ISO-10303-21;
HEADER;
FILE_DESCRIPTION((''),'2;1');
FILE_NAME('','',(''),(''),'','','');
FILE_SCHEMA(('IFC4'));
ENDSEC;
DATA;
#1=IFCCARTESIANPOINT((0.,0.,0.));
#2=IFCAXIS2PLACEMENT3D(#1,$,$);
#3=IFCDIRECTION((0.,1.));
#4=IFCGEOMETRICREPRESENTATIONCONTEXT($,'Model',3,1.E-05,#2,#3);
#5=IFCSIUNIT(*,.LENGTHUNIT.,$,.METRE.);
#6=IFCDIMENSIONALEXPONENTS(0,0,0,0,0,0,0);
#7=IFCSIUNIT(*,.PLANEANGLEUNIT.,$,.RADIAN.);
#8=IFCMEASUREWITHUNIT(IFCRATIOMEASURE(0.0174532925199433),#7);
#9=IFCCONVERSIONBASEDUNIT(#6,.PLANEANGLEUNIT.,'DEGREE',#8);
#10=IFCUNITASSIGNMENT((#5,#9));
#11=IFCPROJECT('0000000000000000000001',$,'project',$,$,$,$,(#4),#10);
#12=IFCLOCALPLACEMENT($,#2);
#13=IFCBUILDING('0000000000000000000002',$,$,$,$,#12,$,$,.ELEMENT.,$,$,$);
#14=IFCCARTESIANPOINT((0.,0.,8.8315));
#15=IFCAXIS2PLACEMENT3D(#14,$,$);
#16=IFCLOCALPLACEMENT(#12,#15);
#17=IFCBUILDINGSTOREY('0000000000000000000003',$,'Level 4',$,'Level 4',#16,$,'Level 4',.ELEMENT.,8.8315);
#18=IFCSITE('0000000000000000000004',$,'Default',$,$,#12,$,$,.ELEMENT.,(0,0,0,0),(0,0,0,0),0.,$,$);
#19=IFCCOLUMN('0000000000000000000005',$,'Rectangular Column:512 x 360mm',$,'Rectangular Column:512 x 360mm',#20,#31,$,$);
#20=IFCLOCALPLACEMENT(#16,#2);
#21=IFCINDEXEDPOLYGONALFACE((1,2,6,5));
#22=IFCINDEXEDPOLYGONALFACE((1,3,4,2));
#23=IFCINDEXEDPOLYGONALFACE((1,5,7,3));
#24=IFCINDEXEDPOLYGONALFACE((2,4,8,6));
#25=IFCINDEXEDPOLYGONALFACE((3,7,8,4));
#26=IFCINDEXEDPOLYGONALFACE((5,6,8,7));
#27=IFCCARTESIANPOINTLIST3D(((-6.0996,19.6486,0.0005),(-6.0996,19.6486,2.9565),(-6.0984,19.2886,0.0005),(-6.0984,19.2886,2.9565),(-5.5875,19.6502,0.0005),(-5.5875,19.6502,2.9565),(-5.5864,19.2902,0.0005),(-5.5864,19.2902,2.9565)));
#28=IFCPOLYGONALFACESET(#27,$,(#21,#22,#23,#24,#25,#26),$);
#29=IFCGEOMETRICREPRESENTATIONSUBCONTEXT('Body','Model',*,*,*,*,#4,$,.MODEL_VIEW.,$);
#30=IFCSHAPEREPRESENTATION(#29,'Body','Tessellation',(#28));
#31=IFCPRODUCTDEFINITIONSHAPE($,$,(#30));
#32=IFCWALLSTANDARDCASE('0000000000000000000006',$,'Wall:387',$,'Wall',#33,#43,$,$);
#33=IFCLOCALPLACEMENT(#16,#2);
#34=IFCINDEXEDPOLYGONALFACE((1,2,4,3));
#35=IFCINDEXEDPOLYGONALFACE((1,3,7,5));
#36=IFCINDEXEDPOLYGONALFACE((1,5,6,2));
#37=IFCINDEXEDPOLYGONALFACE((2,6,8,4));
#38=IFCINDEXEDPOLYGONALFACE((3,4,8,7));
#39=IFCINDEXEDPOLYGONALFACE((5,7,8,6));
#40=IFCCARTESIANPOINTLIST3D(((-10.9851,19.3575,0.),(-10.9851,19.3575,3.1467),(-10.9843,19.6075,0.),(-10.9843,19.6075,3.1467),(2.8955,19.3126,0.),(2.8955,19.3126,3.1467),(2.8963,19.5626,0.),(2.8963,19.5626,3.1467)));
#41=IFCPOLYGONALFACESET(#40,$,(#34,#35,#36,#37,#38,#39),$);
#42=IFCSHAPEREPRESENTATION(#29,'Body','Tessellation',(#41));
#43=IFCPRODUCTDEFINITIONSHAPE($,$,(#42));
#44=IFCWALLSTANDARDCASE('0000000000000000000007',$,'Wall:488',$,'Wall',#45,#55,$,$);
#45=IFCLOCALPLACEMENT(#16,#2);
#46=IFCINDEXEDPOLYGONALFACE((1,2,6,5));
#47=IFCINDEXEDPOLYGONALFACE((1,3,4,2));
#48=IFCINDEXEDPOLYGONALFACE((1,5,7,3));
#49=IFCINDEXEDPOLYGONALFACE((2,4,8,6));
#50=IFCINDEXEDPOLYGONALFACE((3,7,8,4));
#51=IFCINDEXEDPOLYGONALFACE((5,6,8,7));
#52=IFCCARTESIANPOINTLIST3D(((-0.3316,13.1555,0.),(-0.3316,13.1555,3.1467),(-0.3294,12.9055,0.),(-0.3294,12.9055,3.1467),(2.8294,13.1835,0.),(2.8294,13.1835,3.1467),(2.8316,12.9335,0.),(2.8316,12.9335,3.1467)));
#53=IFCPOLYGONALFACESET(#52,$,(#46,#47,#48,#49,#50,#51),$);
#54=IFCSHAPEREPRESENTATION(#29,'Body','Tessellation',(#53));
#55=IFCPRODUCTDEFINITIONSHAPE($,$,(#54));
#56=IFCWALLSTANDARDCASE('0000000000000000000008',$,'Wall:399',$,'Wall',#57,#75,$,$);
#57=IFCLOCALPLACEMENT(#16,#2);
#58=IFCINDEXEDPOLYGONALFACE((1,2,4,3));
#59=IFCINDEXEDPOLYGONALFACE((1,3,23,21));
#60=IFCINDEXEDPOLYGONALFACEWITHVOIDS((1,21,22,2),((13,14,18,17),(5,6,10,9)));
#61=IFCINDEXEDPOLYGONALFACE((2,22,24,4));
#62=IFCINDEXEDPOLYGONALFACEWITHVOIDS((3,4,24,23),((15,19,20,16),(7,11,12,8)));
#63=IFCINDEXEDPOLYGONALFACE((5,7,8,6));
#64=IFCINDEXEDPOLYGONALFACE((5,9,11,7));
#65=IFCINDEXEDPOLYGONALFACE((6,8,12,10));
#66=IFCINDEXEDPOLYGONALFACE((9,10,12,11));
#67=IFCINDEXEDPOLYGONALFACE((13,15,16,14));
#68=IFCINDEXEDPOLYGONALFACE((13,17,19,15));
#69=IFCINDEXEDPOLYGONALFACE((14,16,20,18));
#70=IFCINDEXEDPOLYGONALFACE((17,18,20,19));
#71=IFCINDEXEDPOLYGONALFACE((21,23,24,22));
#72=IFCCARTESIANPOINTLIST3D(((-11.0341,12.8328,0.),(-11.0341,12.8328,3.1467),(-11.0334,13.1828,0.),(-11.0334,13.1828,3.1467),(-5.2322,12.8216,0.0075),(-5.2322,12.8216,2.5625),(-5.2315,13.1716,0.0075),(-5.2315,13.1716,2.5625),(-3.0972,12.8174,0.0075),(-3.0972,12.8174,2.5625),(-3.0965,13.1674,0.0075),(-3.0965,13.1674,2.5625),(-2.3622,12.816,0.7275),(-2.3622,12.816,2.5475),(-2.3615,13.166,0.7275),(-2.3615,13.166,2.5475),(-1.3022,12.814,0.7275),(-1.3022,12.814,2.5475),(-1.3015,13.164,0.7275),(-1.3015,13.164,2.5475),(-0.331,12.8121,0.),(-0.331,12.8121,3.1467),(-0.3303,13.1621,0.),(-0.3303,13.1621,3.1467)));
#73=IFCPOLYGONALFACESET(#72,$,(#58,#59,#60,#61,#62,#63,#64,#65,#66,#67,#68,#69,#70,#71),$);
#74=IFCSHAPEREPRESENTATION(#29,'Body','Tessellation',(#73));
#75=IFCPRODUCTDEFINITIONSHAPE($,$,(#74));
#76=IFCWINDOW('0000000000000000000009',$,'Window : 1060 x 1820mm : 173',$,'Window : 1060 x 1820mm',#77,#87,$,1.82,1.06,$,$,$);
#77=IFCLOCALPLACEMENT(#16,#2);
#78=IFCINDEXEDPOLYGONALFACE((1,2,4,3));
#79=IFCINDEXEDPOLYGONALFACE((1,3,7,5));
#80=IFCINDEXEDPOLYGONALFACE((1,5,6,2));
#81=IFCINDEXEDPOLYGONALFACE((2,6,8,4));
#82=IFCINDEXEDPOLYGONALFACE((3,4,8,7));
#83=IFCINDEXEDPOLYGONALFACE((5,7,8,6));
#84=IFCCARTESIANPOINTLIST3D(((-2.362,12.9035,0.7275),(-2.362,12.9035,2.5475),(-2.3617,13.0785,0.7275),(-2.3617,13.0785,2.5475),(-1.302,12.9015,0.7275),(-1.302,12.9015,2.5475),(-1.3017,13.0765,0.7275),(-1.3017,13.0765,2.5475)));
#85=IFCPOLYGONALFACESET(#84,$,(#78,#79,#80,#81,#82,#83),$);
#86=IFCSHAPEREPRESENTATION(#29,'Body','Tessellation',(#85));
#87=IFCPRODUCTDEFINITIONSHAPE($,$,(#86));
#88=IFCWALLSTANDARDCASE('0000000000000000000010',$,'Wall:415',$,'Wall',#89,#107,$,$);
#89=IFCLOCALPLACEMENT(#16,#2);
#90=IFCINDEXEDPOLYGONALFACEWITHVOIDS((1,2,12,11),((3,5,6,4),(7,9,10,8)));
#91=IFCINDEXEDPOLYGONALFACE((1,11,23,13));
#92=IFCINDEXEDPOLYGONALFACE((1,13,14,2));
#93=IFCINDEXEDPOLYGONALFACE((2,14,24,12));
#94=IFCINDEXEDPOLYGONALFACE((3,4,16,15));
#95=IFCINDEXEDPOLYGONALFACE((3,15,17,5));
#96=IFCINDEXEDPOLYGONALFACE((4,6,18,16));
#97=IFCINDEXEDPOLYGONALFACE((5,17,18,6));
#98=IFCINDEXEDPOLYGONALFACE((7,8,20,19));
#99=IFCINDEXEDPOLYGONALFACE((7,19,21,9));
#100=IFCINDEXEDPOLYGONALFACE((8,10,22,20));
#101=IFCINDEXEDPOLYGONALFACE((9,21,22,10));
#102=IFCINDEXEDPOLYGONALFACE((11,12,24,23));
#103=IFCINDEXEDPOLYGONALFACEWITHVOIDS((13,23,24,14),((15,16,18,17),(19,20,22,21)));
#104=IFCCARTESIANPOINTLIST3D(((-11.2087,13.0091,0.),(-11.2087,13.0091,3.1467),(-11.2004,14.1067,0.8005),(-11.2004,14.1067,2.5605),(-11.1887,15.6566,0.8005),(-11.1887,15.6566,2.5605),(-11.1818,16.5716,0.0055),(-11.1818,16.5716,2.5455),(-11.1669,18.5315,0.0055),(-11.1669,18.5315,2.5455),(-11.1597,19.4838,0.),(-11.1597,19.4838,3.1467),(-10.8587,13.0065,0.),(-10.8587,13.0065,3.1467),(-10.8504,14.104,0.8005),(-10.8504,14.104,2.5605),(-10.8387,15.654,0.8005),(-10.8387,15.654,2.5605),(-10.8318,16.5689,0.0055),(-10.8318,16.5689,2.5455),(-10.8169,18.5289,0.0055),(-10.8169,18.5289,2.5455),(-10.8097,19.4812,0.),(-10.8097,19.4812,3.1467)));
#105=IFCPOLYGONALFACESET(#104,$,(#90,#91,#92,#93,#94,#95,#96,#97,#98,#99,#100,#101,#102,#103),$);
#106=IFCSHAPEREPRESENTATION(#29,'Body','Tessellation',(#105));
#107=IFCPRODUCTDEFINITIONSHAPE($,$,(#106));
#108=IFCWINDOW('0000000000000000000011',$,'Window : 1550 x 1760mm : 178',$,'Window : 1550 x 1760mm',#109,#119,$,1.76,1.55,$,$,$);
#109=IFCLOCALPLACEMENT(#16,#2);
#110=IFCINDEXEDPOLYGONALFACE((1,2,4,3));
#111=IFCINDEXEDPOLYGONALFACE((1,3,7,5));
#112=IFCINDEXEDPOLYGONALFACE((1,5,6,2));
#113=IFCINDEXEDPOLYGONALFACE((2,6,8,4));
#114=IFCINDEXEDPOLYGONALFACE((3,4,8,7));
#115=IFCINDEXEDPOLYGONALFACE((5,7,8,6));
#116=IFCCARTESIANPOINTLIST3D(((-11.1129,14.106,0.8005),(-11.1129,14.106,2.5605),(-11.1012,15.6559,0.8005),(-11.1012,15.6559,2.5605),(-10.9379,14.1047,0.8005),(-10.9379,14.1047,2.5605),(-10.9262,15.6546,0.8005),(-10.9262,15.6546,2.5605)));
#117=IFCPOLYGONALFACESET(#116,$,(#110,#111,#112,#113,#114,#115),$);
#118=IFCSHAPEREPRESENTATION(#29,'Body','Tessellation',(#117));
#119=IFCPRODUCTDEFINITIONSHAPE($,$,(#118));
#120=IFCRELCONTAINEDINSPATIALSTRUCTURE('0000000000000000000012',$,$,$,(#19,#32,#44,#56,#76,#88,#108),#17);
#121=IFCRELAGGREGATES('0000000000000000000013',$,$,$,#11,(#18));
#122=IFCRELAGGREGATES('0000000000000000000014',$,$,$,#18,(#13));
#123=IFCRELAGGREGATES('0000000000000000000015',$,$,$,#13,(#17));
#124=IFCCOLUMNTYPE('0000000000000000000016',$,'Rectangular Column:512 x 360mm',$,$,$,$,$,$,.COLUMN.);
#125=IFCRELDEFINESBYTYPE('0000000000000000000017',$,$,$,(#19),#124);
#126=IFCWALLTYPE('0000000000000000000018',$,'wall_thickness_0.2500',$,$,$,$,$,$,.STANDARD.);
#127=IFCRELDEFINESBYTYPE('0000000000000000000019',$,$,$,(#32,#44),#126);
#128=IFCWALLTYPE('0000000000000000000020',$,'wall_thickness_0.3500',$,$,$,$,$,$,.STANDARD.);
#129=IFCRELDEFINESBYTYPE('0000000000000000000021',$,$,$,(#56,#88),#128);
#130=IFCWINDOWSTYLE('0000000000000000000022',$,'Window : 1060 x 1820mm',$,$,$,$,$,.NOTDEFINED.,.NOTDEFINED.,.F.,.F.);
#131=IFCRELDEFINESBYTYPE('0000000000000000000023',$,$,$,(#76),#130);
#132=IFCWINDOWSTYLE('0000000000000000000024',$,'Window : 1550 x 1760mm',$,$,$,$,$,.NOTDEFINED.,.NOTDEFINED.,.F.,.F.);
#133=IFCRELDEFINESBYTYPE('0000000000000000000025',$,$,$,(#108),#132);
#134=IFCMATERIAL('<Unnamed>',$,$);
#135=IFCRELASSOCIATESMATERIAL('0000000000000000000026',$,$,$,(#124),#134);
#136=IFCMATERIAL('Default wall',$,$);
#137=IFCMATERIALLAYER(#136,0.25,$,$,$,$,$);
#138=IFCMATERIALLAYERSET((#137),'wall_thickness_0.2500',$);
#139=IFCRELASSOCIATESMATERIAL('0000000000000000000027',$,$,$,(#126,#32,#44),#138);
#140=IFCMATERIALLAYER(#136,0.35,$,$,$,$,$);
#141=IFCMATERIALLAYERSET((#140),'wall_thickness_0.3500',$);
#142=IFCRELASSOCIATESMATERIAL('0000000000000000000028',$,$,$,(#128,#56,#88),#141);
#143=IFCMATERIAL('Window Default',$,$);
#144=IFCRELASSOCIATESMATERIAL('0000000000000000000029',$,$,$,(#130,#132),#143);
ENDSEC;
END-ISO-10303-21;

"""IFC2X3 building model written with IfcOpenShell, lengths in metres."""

from ifc_helpers import new_model, entity, si_unit, converted_unit, direction, frame, frame_2d, origin, origin_2d_with_axis, place, context, subcontext, project, spatial, polyline, rectangle, outline, extrude, source, transform, mapped, material, layer, layer_set, layer_usage, type_object, type_shapes, element, fill, save


model = new_model("IFC2X3")

# Units and contexts
model_context = context("Model", 3, precision=1e-05, world=origin(), true_north=direction((0.0, 1.0)))
body_context = subcontext(model_context, "Body", "Model", "MODEL_VIEW")
ifc_project = project(units=[si_unit("LENGTHUNIT", "METRE"), converted_unit("PLANEANGLEUNIT", "DEGREE", entity("IfcRatioMeasure", 0.0174532925199433), si_unit("PLANEANGLEUNIT", "RADIAN"), dimensions=[0, 0, 0, 0, 0, 0, 0])], contexts=[model_context])

# Site, building, storey
placement = place(None, origin())
site = spatial("IfcSite", under=ifc_project, at=placement, Name="Default", CompositionType="ELEMENT", RefLatitude=(0, 0, 0, 0), RefLongitude=(0, 0, 0, 0), RefElevation=0.0)
building = spatial("IfcBuilding", under=site, at=placement, CompositionType="ELEMENT")
storey_placement = place(placement, frame((0.0, 0.0, 8.8315)))
storey = spatial("IfcBuildingStorey", under=building, at=storey_placement, Name="Level 4", ObjectType="Level 4", LongName="Level 4", CompositionType="ELEMENT", Elevation=8.8315)

# Column
ifc_material_1 = material(Name="<Unnamed>")
column_type = type_object("IfcColumnType", Name="Rectangular Column:512 x 360mm", PredefinedType="COLUMN", material=ifc_material_1)
shared_shape_1 = source(origin(), body_context, "Body", "SweptSolid", [
    extrude(rectangle(XDim=0.5121, YDim=0.36, at=origin_2d_with_axis()), frame((0.0, 0.0, 0.0), z_axis=(0.0, 0.0, 1.0), x_axis=(0.0, -1.0, 0.0)), (0.0, 0.0, 1.0), 2.956),
])
type_shapes(column_type, [shared_shape_1])
column_placement = place(placement, frame((-5.843, 19.4694, 8.832), z_axis=(0.0, 0.0, 1.0), x_axis=(0.003156, -0.999995, 0.0)))
element("IfcColumn", 1, at=column_placement, inside=storey, type_object=column_type, Name="Rectangular Column:512 x 360mm", ObjectType="Rectangular Column:512 x 360mm", context=body_context, shape_type="MappedRepresentation", body=[
    mapped(shared_shape_1, transform((0.0, 0.0, 0.0), scale=1.0)),
])

# Walls
ifc_material_2 = material(Name="Default wall")
ifc_layer_1 = layer(ifc_material_2, 0.25)
ifc_layer_set_1 = layer_set([ifc_layer_1], Name="wall_thickness_0.2500")
ifc_layer_usage_1 = layer_usage(ifc_layer_set_1, "AXIS2", "POSITIVE", -0.125)
wall_type_1 = type_object("IfcWallType", Name="wall_thickness_0.2500", PredefinedType="STANDARD", material=ifc_layer_set_1)
wall_1_placement = place(storey_placement, frame((-10.9847, 19.4825, 0.0), z_axis=(0.0, 0.0, 1.0), x_axis=(0.999995, -0.003235, 0.0)))
element("IfcWallStandardCase", 2, at=wall_1_placement, inside=storey, type_object=wall_type_1, material=ifc_layer_usage_1, Name="Wall:387", ObjectType="Wall", context=body_context, shape_type="SweptSolid", body=[
    extrude(outline(polyline([(13.8807, -0.125), (13.8807, 0.125), (0.0, 0.125), (0.0, -0.125), (13.8807, -0.125)])), origin(), (0.0, 0.0, 1.0), 3.1467),
])
wall_2_placement = place(storey_placement, frame((-0.3305, 13.0305, 0.0), z_axis=(0.0, 0.0, 1.0), x_axis=(0.999961, 0.008849, 0.0)))
element("IfcWallStandardCase", 3, at=wall_2_placement, inside=storey, type_object=wall_type_1, material=ifc_layer_usage_1, Name="Wall:488", ObjectType="Wall", context=body_context, shape_type="SweptSolid", body=[
    extrude(outline(polyline([(3.1611, -0.125), (3.1611, 0.125), (0.0, 0.125), (0.0, -0.125), (3.1611, -0.125)])), origin(), (0.0, 0.0, 1.0), 3.1467),
])

# Walls, openings, windows
ifc_layer_2 = layer(ifc_material_2, 0.35)
ifc_layer_set_2 = layer_set([ifc_layer_2], Name="wall_thickness_0.3500")
ifc_layer_usage_2 = layer_usage(ifc_layer_set_2, "AXIS2", "POSITIVE", -0.175)
wall_type_2 = type_object("IfcWallType", Name="wall_thickness_0.3500", PredefinedType="STANDARD", material=ifc_layer_set_2)
wall_3_placement = place(storey_placement, frame((-11.0337, 13.0078, 0.0), z_axis=(0.0, 0.0, 1.0), x_axis=(0.999998, -0.001934, 0.0)))
wall_3 = element("IfcWallStandardCase", 4, at=wall_3_placement, inside=storey, type_object=wall_type_2, material=ifc_layer_usage_2, Name="Wall:399", ObjectType="Wall", context=body_context, shape_type="SweptSolid", body=[
    extrude(outline(polyline([(10.7031, -0.175), (10.7031, 0.175), (0.0, 0.175), (0.0, -0.175), (10.7031, -0.175)])), origin(), (0.0, 0.0, 1.0), 3.1467),
])
opening_1_placement = place(wall_3_placement, frame((5.8019, -0.175, 0.0075)))
element("IfcOpeningElement", 5, at=opening_1_placement, cuts=wall_3, ObjectType="Opening", context=body_context, shape_type="SweptSolid", body=[
    extrude(rectangle(XDim=2.135, YDim=2.555, at=frame_2d((1.2775, 1.0675), x_axis=(0.0, 1.0))), frame((0.0, 0.0, 0.0), z_axis=(0.0, 1.0, 0.0), x_axis=(0.0, 0.0, 1.0)), (0.0, 0.0, 1.0), 0.35),
])
opening_2_placement = place(wall_3_placement, frame((8.6719, -0.175, 0.7275)))
opening_2 = element("IfcOpeningElement", 6, at=opening_2_placement, cuts=wall_3, ObjectType="Opening", context=body_context, shape_type="SweptSolid", body=[
    extrude(rectangle(XDim=1.06, YDim=1.82, at=frame_2d((0.91, 0.53), x_axis=(0.0, 1.0))), frame((0.0, 0.0, 0.0), z_axis=(0.0, 1.0, 0.0), x_axis=(0.0, 0.0, 1.0)), (0.0, 0.0, 1.0), 0.35),
])
ifc_material_3 = material(Name="Window Default")
window_style_1 = type_object("IfcWindowStyle", Name="Window : 1060 x 1820mm", ConstructionType="NOTDEFINED", OperationType="NOTDEFINED", ParameterTakesPrecedence=False, Sizeable=False, material=ifc_material_3)
shared_shape_2 = source(origin(), body_context, "Body", "SweptSolid", [
    extrude(rectangle(XDim=0.175, YDim=1.06, at=origin_2d_with_axis()), frame((0.53, 0.175, 0.0), z_axis=(0.0, 0.0, 1.0), x_axis=(0.0, 1.0, 0.0)), (0.0, 0.0, 1.0), 1.82),
])
type_shapes(window_style_1, [shared_shape_2])
window_1_placement = place(opening_2_placement, origin())
window_1 = element("IfcWindow", 7, at=window_1_placement, inside=storey, type_object=window_style_1, Name="Window : 1060 x 1820mm : 173", ObjectType="Window : 1060 x 1820mm", OverallHeight=1.82, OverallWidth=1.06, context=body_context, shape_type="MappedRepresentation", body=[
    mapped(shared_shape_2, transform((0.0, 0.0, 0.0), scale=1.0)),
])
fill(opening_2, window_1)
wall_4_placement = place(storey_placement, frame((-10.9847, 19.4825, 0.0), z_axis=(0.0, 0.0, 1.0), x_axis=(-0.007568, -0.999971, 0.0)))
wall_4 = element("IfcWallStandardCase", 8, at=wall_4_placement, inside=storey, type_object=wall_type_2, material=ifc_layer_usage_2, Name="Wall:415", ObjectType="Wall", context=body_context, shape_type="SweptSolid", body=[
    extrude(outline(polyline([(6.4749, -0.175), (6.4749, 0.175), (0.0, 0.175), (0.0, -0.175), (6.4749, -0.175)])), origin(), (0.0, 0.0, 1.0), 3.1467),
])
opening_3_placement = place(wall_4_placement, frame((0.9523, -0.175, 0.0055)))
element("IfcOpeningElement", 9, at=opening_3_placement, cuts=wall_4, ObjectType="Opening", context=body_context, shape_type="SweptSolid", body=[
    extrude(rectangle(XDim=1.96, YDim=2.54, at=frame_2d((1.27, 0.98), x_axis=(0.0, 1.0))), frame((0.0, 0.0, 0.0), z_axis=(0.0, 1.0, 0.0), x_axis=(0.0, 0.0, 1.0)), (0.0, 0.0, 1.0), 0.35),
])
opening_4_placement = place(wall_4_placement, frame((3.8273, -0.175, 0.8005)))
opening_4 = element("IfcOpeningElement", 10, at=opening_4_placement, cuts=wall_4, ObjectType="Opening", context=body_context, shape_type="SweptSolid", body=[
    extrude(rectangle(XDim=1.55, YDim=1.76, at=frame_2d((0.88, 0.775), x_axis=(0.0, 1.0))), frame((0.0, 0.0, 0.0), z_axis=(0.0, 1.0, 0.0), x_axis=(0.0, 0.0, 1.0)), (0.0, 0.0, 1.0), 0.35),
])
window_style_2 = type_object("IfcWindowStyle", Name="Window : 1550 x 1760mm", ConstructionType="NOTDEFINED", OperationType="NOTDEFINED", ParameterTakesPrecedence=False, Sizeable=False, material=ifc_material_3)
shared_shape_3 = source(origin(), body_context, "Body", "SweptSolid", [
    extrude(rectangle(XDim=0.175, YDim=1.55, at=origin_2d_with_axis()), frame((0.775, 0.175, 0.0), z_axis=(0.0, 0.0, 1.0), x_axis=(0.0, 1.0, 0.0)), (0.0, 0.0, 1.0), 1.76),
])
type_shapes(window_style_2, [shared_shape_3])
window_2_placement = place(opening_4_placement, origin())
window_2 = element("IfcWindow", 11, at=window_2_placement, inside=storey, type_object=window_style_2, Name="Window : 1550 x 1760mm : 178", ObjectType="Window : 1550 x 1760mm", OverallHeight=1.76, OverallWidth=1.55, context=body_context, shape_type="MappedRepresentation", body=[
    mapped(shared_shape_3, transform((0.0, 0.0, 0.0), scale=1.0)),
])
fill(opening_4, window_2)

save(model, "model.ifc")
